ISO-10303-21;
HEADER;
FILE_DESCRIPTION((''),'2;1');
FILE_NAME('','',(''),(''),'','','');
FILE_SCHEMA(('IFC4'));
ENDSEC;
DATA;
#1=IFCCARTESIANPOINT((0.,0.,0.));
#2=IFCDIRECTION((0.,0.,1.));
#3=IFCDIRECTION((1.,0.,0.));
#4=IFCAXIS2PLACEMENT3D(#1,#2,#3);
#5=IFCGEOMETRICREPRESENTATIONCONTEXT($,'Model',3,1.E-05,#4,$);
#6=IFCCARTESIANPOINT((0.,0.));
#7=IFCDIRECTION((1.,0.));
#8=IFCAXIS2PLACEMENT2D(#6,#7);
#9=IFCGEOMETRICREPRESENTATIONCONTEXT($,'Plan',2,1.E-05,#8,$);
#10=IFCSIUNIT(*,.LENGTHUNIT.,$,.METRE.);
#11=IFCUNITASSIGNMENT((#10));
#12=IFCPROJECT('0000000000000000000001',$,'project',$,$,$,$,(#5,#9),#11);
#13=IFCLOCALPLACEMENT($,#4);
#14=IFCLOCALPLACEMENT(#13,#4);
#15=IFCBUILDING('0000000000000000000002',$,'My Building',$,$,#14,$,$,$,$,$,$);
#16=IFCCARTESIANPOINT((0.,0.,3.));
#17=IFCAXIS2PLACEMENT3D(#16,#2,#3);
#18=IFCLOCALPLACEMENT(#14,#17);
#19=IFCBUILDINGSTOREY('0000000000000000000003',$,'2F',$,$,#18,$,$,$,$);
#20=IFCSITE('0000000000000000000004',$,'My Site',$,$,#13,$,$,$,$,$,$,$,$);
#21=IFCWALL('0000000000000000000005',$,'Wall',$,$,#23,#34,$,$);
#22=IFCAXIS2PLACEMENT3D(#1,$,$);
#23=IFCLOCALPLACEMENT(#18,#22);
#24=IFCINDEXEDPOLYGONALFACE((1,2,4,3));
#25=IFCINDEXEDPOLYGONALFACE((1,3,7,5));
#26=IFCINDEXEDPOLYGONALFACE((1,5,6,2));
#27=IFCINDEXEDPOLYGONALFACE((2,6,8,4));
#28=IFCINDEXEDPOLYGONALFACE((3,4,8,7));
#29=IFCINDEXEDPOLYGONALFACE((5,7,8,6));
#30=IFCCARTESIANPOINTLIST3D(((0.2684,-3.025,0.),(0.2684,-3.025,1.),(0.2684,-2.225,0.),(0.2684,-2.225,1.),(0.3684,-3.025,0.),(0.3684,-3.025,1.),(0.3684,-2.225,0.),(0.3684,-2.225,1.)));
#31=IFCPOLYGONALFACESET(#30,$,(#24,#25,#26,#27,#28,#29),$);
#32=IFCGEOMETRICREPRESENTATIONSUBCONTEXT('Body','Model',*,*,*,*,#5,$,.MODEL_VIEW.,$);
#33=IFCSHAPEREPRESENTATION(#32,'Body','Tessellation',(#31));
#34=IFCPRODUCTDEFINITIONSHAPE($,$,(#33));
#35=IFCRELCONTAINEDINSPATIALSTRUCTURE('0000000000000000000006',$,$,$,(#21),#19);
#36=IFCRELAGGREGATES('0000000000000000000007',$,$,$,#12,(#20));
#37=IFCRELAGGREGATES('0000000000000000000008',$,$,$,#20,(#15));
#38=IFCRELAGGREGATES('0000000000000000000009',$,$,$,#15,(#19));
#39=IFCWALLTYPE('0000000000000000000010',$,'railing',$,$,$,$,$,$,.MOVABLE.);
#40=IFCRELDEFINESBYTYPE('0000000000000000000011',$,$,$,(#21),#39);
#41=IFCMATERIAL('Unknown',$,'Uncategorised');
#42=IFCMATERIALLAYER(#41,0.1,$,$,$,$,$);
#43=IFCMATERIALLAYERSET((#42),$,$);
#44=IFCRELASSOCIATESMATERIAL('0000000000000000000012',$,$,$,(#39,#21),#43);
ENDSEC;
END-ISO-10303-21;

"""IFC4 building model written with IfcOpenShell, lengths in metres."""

from ifc_helpers import new_model, si_unit, frame, origin_with_axes, origin_2d_with_axis, place, context, subcontext, project, spatial, line, indexed_curve, outline, extrude, material, layer, layer_set, layer_usage, type_object, element, save


model = new_model("IFC4")

# Units and contexts
model_context = context("Model", 3, precision=1e-05, world=origin_with_axes())
plan_context = context("Plan", 2, precision=1e-05, world=origin_2d_with_axis())
body_context_1 = subcontext(model_context, "Body", "Model", "MODEL_VIEW")
ifc_project = project(units=[si_unit("LENGTHUNIT", "METRE")], contexts=[model_context, plan_context])

# Site, building, storey
site_placement = place(None, origin_with_axes())
site = spatial("IfcSite", under=ifc_project, at=site_placement, Name="My Site")
building_placement = place(site_placement, origin_with_axes())
building = spatial("IfcBuilding", under=site, at=building_placement, Name="My Building")
storey_placement = place(building_placement, frame((0.0, 0.0, 3.0), z_axis=(0.0, 0.0, 1.0), x_axis=(1.0, 0.0, 0.0)))
storey = spatial("IfcBuildingStorey", under=building, at=storey_placement, Name="2F")

# Shared definitions
ifc_material = material(Name="Unknown", Category="Uncategorised")

# Wall
ifc_layer_1 = layer(ifc_material, 0.1)
ifc_layer_set_1 = layer_set([ifc_layer_1])
wall_type_1 = type_object("IfcWallType", Name="railing", PredefinedType="MOVABLE", material=ifc_layer_set_1)
ifc_layer_usage_1 = layer_usage(ifc_layer_set_1, "AXIS2", "POSITIVE", 0.0)
wall_1_placement = place(storey_placement, frame((0.2684, -2.225, 0.0), z_axis=(0.0, 0.0, 1.0), x_axis=(0.0, -1.0, 0.0)))
element("IfcWall", 1, at=wall_1_placement, inside=storey, type_object=wall_type_1, material=ifc_layer_usage_1, Name="Wall", context=body_context_1, shape_type="SweptSolid", body=[
    extrude(outline(indexed_curve([(0.0, 0.0), (0.0, 0.1), (0.8, 0.1), (0.8, 0.0)], segments=[line(1, 2, 3, 4, 1)])), origin_with_axes(), (0.0, 0.0, 1.0), 1.0),
])

save(model, "model.ifc")
